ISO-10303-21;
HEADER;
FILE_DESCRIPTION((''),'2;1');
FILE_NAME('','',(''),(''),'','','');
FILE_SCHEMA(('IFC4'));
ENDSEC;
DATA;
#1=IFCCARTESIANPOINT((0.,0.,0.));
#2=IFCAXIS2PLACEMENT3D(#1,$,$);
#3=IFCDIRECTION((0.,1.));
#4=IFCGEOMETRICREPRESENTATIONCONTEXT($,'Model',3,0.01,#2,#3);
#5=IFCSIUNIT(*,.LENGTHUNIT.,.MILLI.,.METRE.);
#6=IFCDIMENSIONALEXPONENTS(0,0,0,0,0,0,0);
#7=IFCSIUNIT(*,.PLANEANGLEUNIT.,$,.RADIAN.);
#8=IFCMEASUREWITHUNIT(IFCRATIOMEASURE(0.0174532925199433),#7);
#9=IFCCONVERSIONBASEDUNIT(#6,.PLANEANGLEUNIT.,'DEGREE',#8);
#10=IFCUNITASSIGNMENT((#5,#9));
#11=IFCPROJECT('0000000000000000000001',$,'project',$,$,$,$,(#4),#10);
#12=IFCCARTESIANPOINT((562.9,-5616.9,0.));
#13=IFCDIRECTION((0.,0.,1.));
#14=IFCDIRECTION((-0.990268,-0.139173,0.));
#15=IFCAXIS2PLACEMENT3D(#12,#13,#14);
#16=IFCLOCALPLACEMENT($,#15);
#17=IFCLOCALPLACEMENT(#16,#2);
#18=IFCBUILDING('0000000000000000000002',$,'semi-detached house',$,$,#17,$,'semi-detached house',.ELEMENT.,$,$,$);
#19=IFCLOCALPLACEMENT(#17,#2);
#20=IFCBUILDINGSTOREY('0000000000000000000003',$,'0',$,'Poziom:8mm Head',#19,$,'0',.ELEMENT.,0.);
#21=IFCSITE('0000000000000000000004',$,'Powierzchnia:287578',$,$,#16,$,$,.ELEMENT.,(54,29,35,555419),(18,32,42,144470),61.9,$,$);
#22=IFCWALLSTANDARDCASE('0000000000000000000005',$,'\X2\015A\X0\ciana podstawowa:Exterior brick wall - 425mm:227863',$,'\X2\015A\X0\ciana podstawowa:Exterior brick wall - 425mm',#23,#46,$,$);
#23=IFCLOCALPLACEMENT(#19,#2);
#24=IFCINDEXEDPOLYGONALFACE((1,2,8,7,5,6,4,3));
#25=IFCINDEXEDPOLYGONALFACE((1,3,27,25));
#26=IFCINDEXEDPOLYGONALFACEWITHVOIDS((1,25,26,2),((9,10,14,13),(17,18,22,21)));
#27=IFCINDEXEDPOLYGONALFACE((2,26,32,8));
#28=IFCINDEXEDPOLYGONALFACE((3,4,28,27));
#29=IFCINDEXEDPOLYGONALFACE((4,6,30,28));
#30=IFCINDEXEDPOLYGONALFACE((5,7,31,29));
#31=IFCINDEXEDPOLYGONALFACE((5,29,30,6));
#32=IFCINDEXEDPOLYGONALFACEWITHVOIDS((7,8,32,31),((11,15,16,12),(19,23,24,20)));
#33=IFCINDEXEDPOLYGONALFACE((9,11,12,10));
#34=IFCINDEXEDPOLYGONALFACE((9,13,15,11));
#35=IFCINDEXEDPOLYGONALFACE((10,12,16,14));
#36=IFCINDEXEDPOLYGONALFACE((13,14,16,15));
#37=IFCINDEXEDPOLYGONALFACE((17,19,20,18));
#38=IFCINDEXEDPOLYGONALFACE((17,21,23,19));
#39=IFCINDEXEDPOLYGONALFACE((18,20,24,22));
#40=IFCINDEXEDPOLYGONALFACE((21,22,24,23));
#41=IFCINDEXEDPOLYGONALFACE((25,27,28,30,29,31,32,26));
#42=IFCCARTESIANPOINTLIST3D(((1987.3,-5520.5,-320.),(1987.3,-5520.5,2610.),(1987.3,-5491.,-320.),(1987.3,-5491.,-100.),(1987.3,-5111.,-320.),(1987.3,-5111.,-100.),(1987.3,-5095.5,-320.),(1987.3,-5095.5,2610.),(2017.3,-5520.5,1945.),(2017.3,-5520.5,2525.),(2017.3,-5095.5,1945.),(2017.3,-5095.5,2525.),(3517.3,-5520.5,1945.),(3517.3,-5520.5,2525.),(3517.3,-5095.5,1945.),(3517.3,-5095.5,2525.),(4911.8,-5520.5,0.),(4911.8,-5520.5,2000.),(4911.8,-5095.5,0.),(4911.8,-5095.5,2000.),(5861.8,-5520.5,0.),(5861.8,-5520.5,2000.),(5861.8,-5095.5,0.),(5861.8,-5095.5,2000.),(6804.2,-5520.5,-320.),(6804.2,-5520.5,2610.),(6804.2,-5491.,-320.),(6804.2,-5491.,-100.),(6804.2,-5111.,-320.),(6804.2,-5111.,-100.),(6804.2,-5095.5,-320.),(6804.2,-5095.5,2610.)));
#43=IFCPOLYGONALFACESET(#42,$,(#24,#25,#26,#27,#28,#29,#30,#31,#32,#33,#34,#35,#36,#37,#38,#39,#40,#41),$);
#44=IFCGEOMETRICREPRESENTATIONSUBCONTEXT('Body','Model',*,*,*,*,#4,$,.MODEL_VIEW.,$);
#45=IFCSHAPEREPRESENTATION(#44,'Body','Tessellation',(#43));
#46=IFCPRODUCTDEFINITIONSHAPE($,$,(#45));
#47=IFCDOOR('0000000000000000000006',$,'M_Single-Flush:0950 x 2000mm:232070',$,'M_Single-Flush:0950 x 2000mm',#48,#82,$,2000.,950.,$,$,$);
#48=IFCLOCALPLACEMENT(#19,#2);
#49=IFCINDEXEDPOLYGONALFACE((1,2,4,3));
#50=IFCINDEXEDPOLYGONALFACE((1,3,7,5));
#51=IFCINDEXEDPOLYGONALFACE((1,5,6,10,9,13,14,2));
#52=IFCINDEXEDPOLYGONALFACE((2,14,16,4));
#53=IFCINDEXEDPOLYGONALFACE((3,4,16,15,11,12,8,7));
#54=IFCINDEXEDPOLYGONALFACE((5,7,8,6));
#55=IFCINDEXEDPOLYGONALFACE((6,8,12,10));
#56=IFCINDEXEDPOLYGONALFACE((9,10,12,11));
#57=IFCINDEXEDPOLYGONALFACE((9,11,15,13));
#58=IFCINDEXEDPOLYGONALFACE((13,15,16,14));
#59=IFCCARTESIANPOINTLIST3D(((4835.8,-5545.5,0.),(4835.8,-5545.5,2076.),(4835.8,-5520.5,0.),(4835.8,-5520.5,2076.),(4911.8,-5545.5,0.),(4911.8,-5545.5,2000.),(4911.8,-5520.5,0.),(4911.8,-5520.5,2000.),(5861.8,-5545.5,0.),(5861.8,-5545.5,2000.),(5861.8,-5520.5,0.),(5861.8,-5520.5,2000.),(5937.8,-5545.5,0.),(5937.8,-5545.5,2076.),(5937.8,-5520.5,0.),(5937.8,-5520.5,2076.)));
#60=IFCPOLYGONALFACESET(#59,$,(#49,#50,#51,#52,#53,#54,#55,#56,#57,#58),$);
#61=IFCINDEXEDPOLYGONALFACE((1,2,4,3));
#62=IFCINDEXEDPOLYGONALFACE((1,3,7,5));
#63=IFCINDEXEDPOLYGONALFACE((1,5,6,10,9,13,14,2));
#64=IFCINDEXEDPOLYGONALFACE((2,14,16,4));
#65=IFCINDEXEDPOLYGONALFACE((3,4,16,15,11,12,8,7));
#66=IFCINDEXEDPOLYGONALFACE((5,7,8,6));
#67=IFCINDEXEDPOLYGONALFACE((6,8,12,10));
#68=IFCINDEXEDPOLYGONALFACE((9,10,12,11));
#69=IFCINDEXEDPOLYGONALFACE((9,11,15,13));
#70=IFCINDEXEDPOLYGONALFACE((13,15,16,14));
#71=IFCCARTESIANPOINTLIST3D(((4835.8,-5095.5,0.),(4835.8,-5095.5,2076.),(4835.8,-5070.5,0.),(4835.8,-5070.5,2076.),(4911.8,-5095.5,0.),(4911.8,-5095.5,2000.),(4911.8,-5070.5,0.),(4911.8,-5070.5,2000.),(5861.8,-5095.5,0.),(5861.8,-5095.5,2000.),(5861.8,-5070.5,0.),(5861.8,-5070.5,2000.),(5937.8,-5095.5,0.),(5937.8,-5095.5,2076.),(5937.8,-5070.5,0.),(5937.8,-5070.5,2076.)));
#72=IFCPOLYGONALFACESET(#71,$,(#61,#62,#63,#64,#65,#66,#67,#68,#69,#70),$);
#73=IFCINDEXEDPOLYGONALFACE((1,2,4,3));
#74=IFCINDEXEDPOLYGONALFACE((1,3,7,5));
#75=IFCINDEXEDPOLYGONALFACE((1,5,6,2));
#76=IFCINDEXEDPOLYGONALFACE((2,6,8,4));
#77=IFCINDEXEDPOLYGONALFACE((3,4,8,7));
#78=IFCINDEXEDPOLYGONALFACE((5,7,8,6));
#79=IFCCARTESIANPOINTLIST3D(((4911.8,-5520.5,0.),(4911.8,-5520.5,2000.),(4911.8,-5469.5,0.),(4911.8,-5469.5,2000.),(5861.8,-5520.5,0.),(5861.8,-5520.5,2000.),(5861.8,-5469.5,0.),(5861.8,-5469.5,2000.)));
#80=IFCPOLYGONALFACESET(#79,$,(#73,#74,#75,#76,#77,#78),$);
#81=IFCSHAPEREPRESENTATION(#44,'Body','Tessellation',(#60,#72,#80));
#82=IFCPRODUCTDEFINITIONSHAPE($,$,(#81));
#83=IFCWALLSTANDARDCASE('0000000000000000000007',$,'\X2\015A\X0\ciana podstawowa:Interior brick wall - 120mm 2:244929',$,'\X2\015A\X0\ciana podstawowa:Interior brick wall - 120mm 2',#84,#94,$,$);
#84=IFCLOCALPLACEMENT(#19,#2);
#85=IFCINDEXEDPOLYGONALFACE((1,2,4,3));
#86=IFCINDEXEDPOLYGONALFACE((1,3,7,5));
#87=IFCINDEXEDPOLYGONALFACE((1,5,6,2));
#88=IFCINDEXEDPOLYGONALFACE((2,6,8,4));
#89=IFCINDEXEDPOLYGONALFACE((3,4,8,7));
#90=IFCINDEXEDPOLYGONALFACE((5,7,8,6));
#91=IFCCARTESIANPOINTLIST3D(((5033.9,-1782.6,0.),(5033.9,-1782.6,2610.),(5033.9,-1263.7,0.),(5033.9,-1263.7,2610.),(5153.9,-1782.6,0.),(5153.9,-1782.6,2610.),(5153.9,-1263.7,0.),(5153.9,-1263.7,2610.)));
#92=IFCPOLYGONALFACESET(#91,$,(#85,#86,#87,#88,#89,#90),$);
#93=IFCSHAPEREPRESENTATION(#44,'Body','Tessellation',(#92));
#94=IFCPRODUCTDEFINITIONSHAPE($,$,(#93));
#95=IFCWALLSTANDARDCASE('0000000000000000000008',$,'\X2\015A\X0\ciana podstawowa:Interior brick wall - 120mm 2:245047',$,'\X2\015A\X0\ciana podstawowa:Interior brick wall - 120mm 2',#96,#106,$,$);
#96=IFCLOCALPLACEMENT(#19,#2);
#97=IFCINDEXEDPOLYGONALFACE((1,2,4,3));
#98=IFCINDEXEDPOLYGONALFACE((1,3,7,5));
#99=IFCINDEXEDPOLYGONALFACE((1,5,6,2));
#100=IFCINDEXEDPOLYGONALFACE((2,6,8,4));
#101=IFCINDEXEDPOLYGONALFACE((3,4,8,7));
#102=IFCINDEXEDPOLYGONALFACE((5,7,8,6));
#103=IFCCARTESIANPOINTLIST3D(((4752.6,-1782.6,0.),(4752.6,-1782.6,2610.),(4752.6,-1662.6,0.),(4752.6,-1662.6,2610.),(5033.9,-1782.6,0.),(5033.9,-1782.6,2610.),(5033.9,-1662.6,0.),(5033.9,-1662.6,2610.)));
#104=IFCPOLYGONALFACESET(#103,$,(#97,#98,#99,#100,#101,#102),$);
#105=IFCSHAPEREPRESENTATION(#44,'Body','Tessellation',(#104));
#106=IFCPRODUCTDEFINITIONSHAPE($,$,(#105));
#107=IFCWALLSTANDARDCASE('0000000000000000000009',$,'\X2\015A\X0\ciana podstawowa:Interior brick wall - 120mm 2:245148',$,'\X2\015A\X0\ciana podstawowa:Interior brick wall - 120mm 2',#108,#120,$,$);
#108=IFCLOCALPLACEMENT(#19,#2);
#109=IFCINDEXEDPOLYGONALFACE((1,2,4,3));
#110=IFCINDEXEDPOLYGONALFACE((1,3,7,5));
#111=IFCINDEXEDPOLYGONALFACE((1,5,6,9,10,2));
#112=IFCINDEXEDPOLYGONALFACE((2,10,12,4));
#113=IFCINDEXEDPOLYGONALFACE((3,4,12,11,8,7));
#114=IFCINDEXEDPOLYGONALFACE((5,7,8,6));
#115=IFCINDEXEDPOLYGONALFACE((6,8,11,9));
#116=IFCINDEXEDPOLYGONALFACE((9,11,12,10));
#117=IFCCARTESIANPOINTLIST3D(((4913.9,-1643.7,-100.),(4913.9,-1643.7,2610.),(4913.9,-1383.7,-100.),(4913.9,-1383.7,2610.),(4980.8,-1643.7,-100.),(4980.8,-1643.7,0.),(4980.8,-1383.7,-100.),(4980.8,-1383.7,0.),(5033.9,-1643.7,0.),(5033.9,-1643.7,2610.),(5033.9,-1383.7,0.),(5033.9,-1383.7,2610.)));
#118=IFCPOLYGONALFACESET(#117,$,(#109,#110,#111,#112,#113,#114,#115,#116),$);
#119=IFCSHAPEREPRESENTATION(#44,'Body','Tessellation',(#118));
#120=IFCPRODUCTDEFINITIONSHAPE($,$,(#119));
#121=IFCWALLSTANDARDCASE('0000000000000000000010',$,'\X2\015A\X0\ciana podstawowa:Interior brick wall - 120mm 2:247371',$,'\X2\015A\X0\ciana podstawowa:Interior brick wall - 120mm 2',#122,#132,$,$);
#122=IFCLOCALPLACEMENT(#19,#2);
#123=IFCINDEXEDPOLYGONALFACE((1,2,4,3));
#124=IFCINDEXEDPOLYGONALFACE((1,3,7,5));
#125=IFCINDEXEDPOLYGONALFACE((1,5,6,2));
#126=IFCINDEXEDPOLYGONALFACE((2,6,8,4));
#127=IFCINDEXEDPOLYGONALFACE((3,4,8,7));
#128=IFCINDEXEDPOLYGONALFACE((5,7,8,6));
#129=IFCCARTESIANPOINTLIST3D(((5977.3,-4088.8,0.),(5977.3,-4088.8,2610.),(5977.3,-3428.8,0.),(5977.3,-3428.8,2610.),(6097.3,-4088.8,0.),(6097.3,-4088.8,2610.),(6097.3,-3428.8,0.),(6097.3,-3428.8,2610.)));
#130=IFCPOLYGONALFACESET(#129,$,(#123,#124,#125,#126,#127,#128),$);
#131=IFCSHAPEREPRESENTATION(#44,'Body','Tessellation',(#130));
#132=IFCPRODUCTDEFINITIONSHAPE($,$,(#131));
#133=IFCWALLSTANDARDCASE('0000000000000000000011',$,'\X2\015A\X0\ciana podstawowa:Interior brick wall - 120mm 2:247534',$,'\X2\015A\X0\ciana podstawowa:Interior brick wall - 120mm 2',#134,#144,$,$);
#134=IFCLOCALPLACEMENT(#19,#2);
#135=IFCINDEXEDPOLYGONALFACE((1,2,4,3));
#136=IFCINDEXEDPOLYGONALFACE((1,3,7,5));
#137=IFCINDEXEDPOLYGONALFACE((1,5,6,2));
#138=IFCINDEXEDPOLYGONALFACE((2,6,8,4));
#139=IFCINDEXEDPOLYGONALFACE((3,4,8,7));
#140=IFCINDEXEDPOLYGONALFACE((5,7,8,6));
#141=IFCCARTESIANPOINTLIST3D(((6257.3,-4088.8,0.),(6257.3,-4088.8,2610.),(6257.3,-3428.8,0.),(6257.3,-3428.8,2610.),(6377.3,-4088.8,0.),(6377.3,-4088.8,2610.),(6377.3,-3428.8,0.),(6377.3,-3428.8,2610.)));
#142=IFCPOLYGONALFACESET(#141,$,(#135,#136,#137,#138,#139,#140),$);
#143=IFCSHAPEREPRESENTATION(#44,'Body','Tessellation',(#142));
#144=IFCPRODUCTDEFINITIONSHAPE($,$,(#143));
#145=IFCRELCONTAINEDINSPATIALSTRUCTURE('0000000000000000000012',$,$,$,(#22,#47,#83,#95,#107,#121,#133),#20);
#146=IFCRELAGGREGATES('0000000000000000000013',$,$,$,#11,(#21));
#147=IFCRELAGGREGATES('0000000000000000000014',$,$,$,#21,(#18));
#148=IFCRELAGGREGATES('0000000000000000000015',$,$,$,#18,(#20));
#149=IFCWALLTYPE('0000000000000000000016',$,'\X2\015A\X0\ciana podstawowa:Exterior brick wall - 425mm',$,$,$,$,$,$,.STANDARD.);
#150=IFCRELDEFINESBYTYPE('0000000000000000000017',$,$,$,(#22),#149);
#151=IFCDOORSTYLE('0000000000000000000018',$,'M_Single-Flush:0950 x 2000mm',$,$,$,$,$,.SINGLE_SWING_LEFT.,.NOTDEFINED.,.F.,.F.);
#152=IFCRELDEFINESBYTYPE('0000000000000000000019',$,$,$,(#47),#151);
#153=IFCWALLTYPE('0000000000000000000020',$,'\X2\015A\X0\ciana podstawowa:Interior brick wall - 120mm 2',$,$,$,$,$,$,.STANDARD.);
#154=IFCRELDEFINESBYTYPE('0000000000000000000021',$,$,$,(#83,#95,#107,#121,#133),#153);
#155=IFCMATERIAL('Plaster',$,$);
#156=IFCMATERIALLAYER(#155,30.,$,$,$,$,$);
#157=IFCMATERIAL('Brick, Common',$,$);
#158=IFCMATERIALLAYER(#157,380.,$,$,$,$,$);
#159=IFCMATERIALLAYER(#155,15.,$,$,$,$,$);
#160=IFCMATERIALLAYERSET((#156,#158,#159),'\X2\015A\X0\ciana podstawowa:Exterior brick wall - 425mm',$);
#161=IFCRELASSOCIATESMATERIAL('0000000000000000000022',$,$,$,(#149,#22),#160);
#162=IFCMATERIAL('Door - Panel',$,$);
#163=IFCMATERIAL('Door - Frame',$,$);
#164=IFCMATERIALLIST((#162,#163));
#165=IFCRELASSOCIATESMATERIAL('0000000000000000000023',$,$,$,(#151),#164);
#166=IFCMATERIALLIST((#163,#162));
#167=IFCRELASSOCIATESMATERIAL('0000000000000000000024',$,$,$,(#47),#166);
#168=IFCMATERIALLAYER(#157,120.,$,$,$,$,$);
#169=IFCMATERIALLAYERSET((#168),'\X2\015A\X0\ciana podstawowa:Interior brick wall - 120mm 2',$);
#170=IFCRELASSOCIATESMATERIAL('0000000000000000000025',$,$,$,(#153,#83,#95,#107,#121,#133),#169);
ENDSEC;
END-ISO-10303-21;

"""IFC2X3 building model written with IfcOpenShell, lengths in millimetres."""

from ifc_helpers import new_model, entity, si_unit, converted_unit, direction, frame, frame_2d, origin, place, context, subcontext, project, spatial, polyline, rectangle, outline, extrude, clip, bounded_halfspace, source, transform, mapped, material, material_list, layer, layer_set, layer_usage, type_object, type_shapes, element, fill, save


model = new_model("IFC2X3")

# Units and contexts
model_context = context("Model", 3, precision=0.01, world=origin(), true_north=direction((0.0, 1.0)))
body_context = subcontext(model_context, "Body", "Model", "MODEL_VIEW")
ifc_project = project(units=[si_unit("LENGTHUNIT", "METRE", prefix="MILLI"), converted_unit("PLANEANGLEUNIT", "DEGREE", entity("IfcRatioMeasure", 0.0174532925199433), si_unit("PLANEANGLEUNIT", "RADIAN"), dimensions=[0, 0, 0, 0, 0, 0, 0])], contexts=[model_context])

# Site, building, storey
site_placement = place(None, frame((562.9, -5616.9, 0.0), z_axis=(0.0, 0.0, 1.0), x_axis=(-0.990268, -0.139173, 0.0)))
site = spatial("IfcSite", under=ifc_project, at=site_placement, Name="Powierzchnia:287578", CompositionType="ELEMENT", RefLatitude=(54, 29, 35, 555419), RefLongitude=(18, 32, 42, 144470), RefElevation=61.9)
building_placement = place(site_placement, origin())
building = spatial("IfcBuilding", under=site, at=building_placement, Name="semi-detached house", LongName="semi-detached house", CompositionType="ELEMENT")
storey_placement = place(building_placement, origin())
storey = spatial("IfcBuildingStorey", under=building, at=storey_placement, Name="0", ObjectType="Poziom:8mm Head", LongName="0", CompositionType="ELEMENT", Elevation=0.0)

# Shared definitions
ifc_material_1 = material(Name="Plaster")
ifc_material_2 = material(Name="Brick, Common")

# Wall, openings, door
ifc_layer_1 = layer(ifc_material_1, 30.0)
ifc_layer_2 = layer(ifc_material_2, 380.0)
ifc_layer_3 = layer(ifc_material_1, 15.0)
ifc_layer_set_1 = layer_set([ifc_layer_1, ifc_layer_2, ifc_layer_3], Name="Ściana podstawowa:Exterior brick wall - 425mm")
ifc_layer_usage_1 = layer_usage(ifc_layer_set_1, "AXIS2", "NEGATIVE", 212.5)
wall_type_1 = type_object("IfcWallType", Name="Ściana podstawowa:Exterior brick wall - 425mm", PredefinedType="STANDARD", material=ifc_layer_set_1)
wall_1_placement = place(storey_placement, frame((6804.2, -5308.0, -320.0), z_axis=(0.0, 0.0, 1.0), x_axis=(-1.0, 0.0, 0.0)))
wall_1 = element("IfcWallStandardCase", 1, at=wall_1_placement, inside=storey, type_object=wall_type_1, material=ifc_layer_usage_1, Name="Ściana podstawowa:Exterior brick wall - 425mm:227863", ObjectType="Ściana podstawowa:Exterior brick wall - 425mm", context=body_context, shape_type="Clipping", body=[
    clip(clip(extrude(rectangle(XDim=4816.9, YDim=425.0, at=frame_2d((2408.4, 0.0), x_axis=(-1.0, 0.0))), origin(), (0.0, 0.0, 1.0), 2930.0), bounded_halfspace(frame((3651.9, -212.5, 2930.0), z_axis=(0.0, 0.0, -1.0), x_axis=(-1.0, 0.0, 0.0)), True, frame((3651.9, -212.5, 2930.0)), polyline([(0.0, 0.0), (1165.0, 0.0), (1165.0, 4.8), (0.0, 4.8), (0.0, 0.0)]))), bounded_halfspace(frame((4816.9, -197.0, 220.0)), True, frame((4816.9, -197.0, 220.0)), polyline([(0.0, 0.0), (0.0, 380.0), (-4816.9, 380.0), (-4816.9, 0.0), (0.0, 0.0)]))),
])
opening_1_placement = place(wall_1_placement, origin())
element("IfcOpeningElement", 2, at=opening_1_placement, cuts=wall_1, ObjectType="Opening", context=body_context, shape_type="SweptSolid", body=[
    extrude(rectangle(XDim=2000.0, YDim=120.0, at=frame_2d((0.0, 0.0), x_axis=(0.0, 1.0))), frame((2334.1, -985.4, 1320.0), z_axis=(0.0, 1.0, 0.0), x_axis=(-1.0, 0.0, 0.0)), (0.0, 0.0, 1.0), 750.0),
])
opening_2_placement = place(wall_1_placement, frame((3286.9, -212.5, 2265.0)))
element("IfcOpeningElement", 3, at=opening_2_placement, cuts=wall_1, ObjectType="Opening", context=body_context, shape_type="SweptSolid", body=[
    extrude(rectangle(XDim=580.0, YDim=1500.0, at=frame_2d((290.0, 750.0), x_axis=(-1.0, 0.0))), frame((0.0, 0.0, 0.0), z_axis=(0.0, 1.0, 0.0), x_axis=(0.0, 0.0, 1.0)), (0.0, 0.0, 1.0), 425.0),
])
opening_3_placement = place(wall_1_placement, frame((942.3, -212.5, 320.0)))
opening_3 = element("IfcOpeningElement", 4, at=opening_3_placement, cuts=wall_1, ObjectType="Opening", context=body_context, shape_type="SweptSolid", body=[
    extrude(rectangle(XDim=950.0, YDim=2000.0, at=frame_2d((1000.0, 475.0), x_axis=(0.0, -1.0))), frame((0.0, 0.0, 0.0), z_axis=(0.0, 1.0, 0.0), x_axis=(0.0, 0.0, 1.0)), (0.0, 0.0, 1.0), 425.0),
])
ifc_material_3 = material(Name="Door - Frame")
ifc_material_4 = material(Name="Door - Panel")
ifc_material_list_1 = material_list([ifc_material_3, ifc_material_4])
ifc_material_list_2 = material_list([ifc_material_4, ifc_material_3])
door_style = type_object("IfcDoorStyle", Name="M_Single-Flush:0950 x 2000mm", ConstructionType="NOTDEFINED", OperationType="SINGLE_SWING_LEFT", ParameterTakesPrecedence=False, Sizeable=False, material=ifc_material_list_2)
shared_shape = source(origin(), body_context, "Body", "SweptSolid", [
    extrude(outline(polyline([(-551.0, -1057.0), (551.0, -1057.0), (551.0, 1019.0), (475.0, 1019.0), (475.0, -981.0), (-475.0, -981.0), (-475.0, 1019.0), (-551.0, 1019.0), (-551.0, -1057.0)])), frame((475.0, 450.0, 1019.0), z_axis=(0.0, -1.0, 0.0), x_axis=(-1.0, 0.0, 0.0)), (0.0, 0.0, 1.0), 25.0),
    extrude(outline(polyline([(-1057.0, -551.0), (1019.0, -551.0), (1019.0, -475.0), (-981.0, -475.0), (-981.0, 475.0), (1019.0, 475.0), (1019.0, 551.0), (-1057.0, 551.0), (-1057.0, -551.0)])), frame((475.0, 0.0, 1019.0), z_axis=(0.0, -1.0, 0.0), x_axis=(0.0, 0.0, -1.0)), (0.0, 0.0, 1.0), 25.0),
    extrude(rectangle(XDim=950.0, YDim=51.0, at=frame_2d((0.0, 0.0), x_axis=(1.0, 0.0))), frame((475.0, 399.5, 0.0)), (0.0, 0.0, 1.0), 2000.0),
])
type_shapes(door_style, [shared_shape])
door_placement = place(opening_3_placement, origin())
door = element("IfcDoor", 5, at=door_placement, inside=storey, type_object=door_style, material=ifc_material_list_1, Name="M_Single-Flush:0950 x 2000mm:232070", ObjectType="M_Single-Flush:0950 x 2000mm", OverallHeight=2000.0, OverallWidth=950.0, context=body_context, shape_type="MappedRepresentation", body=[
    mapped(shared_shape, transform((0.0, 0.0, 0.0), scale=1.0)),
])
fill(opening_3, door)

# Walls
ifc_layer_4 = layer(ifc_material_2, 120.0)
ifc_layer_set_2 = layer_set([ifc_layer_4], Name="Ściana podstawowa:Interior brick wall - 120mm 2")
ifc_layer_usage_2 = layer_usage(ifc_layer_set_2, "AXIS2", "POSITIVE", -60.0)
wall_type_2 = type_object("IfcWallType", Name="Ściana podstawowa:Interior brick wall - 120mm 2", PredefinedType="STANDARD", material=ifc_layer_set_2)
wall_2_placement = place(storey_placement, frame((5093.9, -1782.6, 0.0), z_axis=(0.0, 0.0, 1.0), x_axis=(0.0, 1.0, 0.0)))
element("IfcWallStandardCase", 6, at=wall_2_placement, inside=storey, type_object=wall_type_2, material=ifc_layer_usage_2, Name="Ściana podstawowa:Interior brick wall - 120mm 2:244929", ObjectType="Ściana podstawowa:Interior brick wall - 120mm 2", context=body_context, shape_type="Clipping", body=[
    clip(clip(extrude(rectangle(XDim=518.9, YDim=120.0, at=frame_2d((259.5, 0.0), x_axis=(-1.0, 0.0))), origin(), (0.0, 0.0, 1.0), 2610.0), bounded_halfspace(frame((0.0, -60.0, 2610.0), z_axis=(0.0, 0.0, -1.0), x_axis=(0.0, -1.0, 0.0)), True, frame((0.0, -60.0, 2610.0)), polyline([(0.0, 0.0), (518.9, 0.0), (518.9, 120.0), (398.9, 120.0), (138.9, 120.0), (120.0, 120.0), (0.0, 120.0), (0.0, 0.0)]))), bounded_halfspace(frame((518.9, -60.0, 0.0), z_axis=(0.0, 0.0, 1.0), x_axis=(-1.0, 0.0, 0.0)), True, frame((518.9, -60.0, 0.0), z_axis=(0.0, 0.0, 1.0), x_axis=(-1.0, 0.0, 0.0)), polyline([(0.0, 0.0), (0.0, -120.0), (120.0, -120.0), (380.0, -120.0), (398.9, -120.0), (518.9, -120.0), (518.9, 0.0), (0.0, 0.0)]))),
])
ifc_layer_usage_3 = layer_usage(ifc_layer_set_2, "AXIS2", "POSITIVE", -60.0)
wall_3_placement = place(storey_placement, frame((4752.6, -1722.6, 0.0)))
element("IfcWallStandardCase", 7, at=wall_3_placement, inside=storey, type_object=wall_type_2, material=ifc_layer_usage_3, Name="Ściana podstawowa:Interior brick wall - 120mm 2:245047", ObjectType="Ściana podstawowa:Interior brick wall - 120mm 2", context=body_context, shape_type="Clipping", body=[
    clip(clip(extrude(rectangle(XDim=281.3, YDim=120.0, at=frame_2d((140.7, 0.0), x_axis=(-1.0, 0.0))), origin(), (0.0, 0.0, 1.0), 2610.0), bounded_halfspace(frame((0.0, -60.0, 2610.0), z_axis=(0.0, 0.0, -1.0), x_axis=(1.0, 0.0, 0.0)), True, frame((0.0, -60.0, 2610.0)), polyline([(0.0, 0.0), (201.3, 0.0), (281.3, 0.0), (281.3, 120.0), (0.0, 120.0), (0.0, 0.0)]))), bounded_halfspace(frame((281.3, -60.0, 0.0), z_axis=(0.0, 0.0, 1.0), x_axis=(0.0, -1.0, 0.0)), True, frame((281.3, -60.0, 0.0), z_axis=(0.0, 0.0, 1.0), x_axis=(0.0, -1.0, 0.0)), polyline([(0.0, 0.0), (-120.0, 0.0), (-120.0, -281.3), (0.0, -281.3), (0.0, -80.0), (0.0, 0.0)]))),
])
ifc_layer_usage_4 = layer_usage(ifc_layer_set_2, "AXIS2", "POSITIVE", -60.0)
wall_4_placement = place(storey_placement, frame((4973.9, -1643.7, -100.0), z_axis=(0.0, 0.0, 1.0), x_axis=(0.0, 1.0, 0.0)))
element("IfcWallStandardCase", 8, at=wall_4_placement, inside=storey, type_object=wall_type_2, material=ifc_layer_usage_4, Name="Ściana podstawowa:Interior brick wall - 120mm 2:245148", ObjectType="Ściana podstawowa:Interior brick wall - 120mm 2", context=body_context, shape_type="Clipping", body=[
    clip(clip(clip(extrude(rectangle(XDim=260.0, YDim=120.0, at=frame_2d((130.0, 0.0), x_axis=(-1.0, 0.0))), origin(), (0.0, 0.0, 1.0), 2710.0), bounded_halfspace(frame((0.0, -60.0, 2710.0), z_axis=(0.0, 0.0, -1.0), x_axis=(0.0, -1.0, 0.0)), True, frame((0.0, -60.0, 2710.0)), polyline([(0.0, 0.0), (260.0, 0.0), (260.0, 120.0), (120.0, 120.0), (0.0, 120.0), (0.0, 0.0)]))), bounded_halfspace(frame((0.0, -6.9, 100.0), z_axis=(0.0, 0.0, 1.0), x_axis=(-1.0, 0.0, 0.0)), True, frame((0.0, -6.9, 100.0), z_axis=(0.0, 0.0, 1.0), x_axis=(-1.0, 0.0, 0.0)), polyline([(0.0, 0.0), (0.0, 53.1), (-260.0, 53.1), (-260.0, 0.0), (0.0, 0.0)]))), bounded_halfspace(frame((260.0, -6.9, 100.0), z_axis=(0.0, 1.0, 0.0), x_axis=(0.0, 0.0, 1.0)), True, frame((260.0, -6.9, 100.0), z_axis=(0.0, 1.0, 0.0), x_axis=(0.0, 0.0, 1.0)), polyline([(0.0, 0.0), (-100.0, 0.0), (-100.0, -260.0), (0.0, -260.0), (0.0, 0.0)]))),
])
ifc_layer_usage_5 = layer_usage(ifc_layer_set_2, "AXIS2", "POSITIVE", -60.0)
wall_5_placement = place(storey_placement, frame((6037.3, -3428.8, 0.0), z_axis=(0.0, 0.0, 1.0), x_axis=(0.0, -1.0, 0.0)))
element("IfcWallStandardCase", 9, at=wall_5_placement, inside=storey, type_object=wall_type_2, material=ifc_layer_usage_5, Name="Ściana podstawowa:Interior brick wall - 120mm 2:247371", ObjectType="Ściana podstawowa:Interior brick wall - 120mm 2", context=body_context, shape_type="Clipping", body=[
    clip(clip(extrude(rectangle(XDim=660.0, YDim=120.0, at=frame_2d((330.0, 0.0), x_axis=(-1.0, 0.0))), origin(), (0.0, 0.0, 1.0), 2610.0), bounded_halfspace(frame((0.0, -60.0, 2610.0), z_axis=(0.0, 0.0, -1.0), x_axis=(0.0, 1.0, 0.0)), True, frame((0.0, -60.0, 2610.0)), polyline([(0.0, 0.0), (660.0, 0.0), (660.0, 120.0), (520.0, 120.0), (400.0, 120.0), (260.0, 120.0), (140.0, 120.0), (0.0, 120.0), (0.0, 0.0)]))), bounded_halfspace(frame((660.0, -60.0, 0.0)), True, frame((660.0, -60.0, 0.0)), polyline([(0.0, 0.0), (0.0, 120.0), (-140.0, 120.0), (-260.0, 120.0), (-400.0, 120.0), (-520.0, 120.0), (-660.0, 120.0), (-660.0, 0.0), (0.0, 0.0)]))),
])
ifc_layer_usage_6 = layer_usage(ifc_layer_set_2, "AXIS2", "NEGATIVE", 60.0)
wall_6_placement = place(storey_placement, frame((6317.3, -3428.8, 0.0), z_axis=(0.0, 0.0, 1.0), x_axis=(0.0, -1.0, 0.0)))
element("IfcWallStandardCase", 10, at=wall_6_placement, inside=storey, type_object=wall_type_2, material=ifc_layer_usage_6, Name="Ściana podstawowa:Interior brick wall - 120mm 2:247534", ObjectType="Ściana podstawowa:Interior brick wall - 120mm 2", context=body_context, shape_type="Clipping", body=[
    clip(clip(extrude(rectangle(XDim=660.0, YDim=120.0, at=frame_2d((330.0, 0.0), x_axis=(-1.0, 0.0))), origin(), (0.0, 0.0, 1.0), 2610.0), bounded_halfspace(frame((0.0, -60.0, 2610.0), z_axis=(0.0, 0.0, -1.0), x_axis=(0.0, 1.0, 0.0)), True, frame((0.0, -60.0, 2610.0)), polyline([(0.0, 0.0), (140.0, 0.0), (260.0, 0.0), (400.0, 0.0), (520.0, 0.0), (660.0, 0.0), (660.0, 120.0), (0.0, 120.0), (0.0, 0.0)]))), bounded_halfspace(frame((660.0, -60.0, 0.0)), True, frame((660.0, -60.0, 0.0)), polyline([(0.0, 0.0), (0.0, 120.0), (-660.0, 120.0), (-660.0, 0.0), (0.0, 0.0)]))),
])

save(model, "model.ifc")
